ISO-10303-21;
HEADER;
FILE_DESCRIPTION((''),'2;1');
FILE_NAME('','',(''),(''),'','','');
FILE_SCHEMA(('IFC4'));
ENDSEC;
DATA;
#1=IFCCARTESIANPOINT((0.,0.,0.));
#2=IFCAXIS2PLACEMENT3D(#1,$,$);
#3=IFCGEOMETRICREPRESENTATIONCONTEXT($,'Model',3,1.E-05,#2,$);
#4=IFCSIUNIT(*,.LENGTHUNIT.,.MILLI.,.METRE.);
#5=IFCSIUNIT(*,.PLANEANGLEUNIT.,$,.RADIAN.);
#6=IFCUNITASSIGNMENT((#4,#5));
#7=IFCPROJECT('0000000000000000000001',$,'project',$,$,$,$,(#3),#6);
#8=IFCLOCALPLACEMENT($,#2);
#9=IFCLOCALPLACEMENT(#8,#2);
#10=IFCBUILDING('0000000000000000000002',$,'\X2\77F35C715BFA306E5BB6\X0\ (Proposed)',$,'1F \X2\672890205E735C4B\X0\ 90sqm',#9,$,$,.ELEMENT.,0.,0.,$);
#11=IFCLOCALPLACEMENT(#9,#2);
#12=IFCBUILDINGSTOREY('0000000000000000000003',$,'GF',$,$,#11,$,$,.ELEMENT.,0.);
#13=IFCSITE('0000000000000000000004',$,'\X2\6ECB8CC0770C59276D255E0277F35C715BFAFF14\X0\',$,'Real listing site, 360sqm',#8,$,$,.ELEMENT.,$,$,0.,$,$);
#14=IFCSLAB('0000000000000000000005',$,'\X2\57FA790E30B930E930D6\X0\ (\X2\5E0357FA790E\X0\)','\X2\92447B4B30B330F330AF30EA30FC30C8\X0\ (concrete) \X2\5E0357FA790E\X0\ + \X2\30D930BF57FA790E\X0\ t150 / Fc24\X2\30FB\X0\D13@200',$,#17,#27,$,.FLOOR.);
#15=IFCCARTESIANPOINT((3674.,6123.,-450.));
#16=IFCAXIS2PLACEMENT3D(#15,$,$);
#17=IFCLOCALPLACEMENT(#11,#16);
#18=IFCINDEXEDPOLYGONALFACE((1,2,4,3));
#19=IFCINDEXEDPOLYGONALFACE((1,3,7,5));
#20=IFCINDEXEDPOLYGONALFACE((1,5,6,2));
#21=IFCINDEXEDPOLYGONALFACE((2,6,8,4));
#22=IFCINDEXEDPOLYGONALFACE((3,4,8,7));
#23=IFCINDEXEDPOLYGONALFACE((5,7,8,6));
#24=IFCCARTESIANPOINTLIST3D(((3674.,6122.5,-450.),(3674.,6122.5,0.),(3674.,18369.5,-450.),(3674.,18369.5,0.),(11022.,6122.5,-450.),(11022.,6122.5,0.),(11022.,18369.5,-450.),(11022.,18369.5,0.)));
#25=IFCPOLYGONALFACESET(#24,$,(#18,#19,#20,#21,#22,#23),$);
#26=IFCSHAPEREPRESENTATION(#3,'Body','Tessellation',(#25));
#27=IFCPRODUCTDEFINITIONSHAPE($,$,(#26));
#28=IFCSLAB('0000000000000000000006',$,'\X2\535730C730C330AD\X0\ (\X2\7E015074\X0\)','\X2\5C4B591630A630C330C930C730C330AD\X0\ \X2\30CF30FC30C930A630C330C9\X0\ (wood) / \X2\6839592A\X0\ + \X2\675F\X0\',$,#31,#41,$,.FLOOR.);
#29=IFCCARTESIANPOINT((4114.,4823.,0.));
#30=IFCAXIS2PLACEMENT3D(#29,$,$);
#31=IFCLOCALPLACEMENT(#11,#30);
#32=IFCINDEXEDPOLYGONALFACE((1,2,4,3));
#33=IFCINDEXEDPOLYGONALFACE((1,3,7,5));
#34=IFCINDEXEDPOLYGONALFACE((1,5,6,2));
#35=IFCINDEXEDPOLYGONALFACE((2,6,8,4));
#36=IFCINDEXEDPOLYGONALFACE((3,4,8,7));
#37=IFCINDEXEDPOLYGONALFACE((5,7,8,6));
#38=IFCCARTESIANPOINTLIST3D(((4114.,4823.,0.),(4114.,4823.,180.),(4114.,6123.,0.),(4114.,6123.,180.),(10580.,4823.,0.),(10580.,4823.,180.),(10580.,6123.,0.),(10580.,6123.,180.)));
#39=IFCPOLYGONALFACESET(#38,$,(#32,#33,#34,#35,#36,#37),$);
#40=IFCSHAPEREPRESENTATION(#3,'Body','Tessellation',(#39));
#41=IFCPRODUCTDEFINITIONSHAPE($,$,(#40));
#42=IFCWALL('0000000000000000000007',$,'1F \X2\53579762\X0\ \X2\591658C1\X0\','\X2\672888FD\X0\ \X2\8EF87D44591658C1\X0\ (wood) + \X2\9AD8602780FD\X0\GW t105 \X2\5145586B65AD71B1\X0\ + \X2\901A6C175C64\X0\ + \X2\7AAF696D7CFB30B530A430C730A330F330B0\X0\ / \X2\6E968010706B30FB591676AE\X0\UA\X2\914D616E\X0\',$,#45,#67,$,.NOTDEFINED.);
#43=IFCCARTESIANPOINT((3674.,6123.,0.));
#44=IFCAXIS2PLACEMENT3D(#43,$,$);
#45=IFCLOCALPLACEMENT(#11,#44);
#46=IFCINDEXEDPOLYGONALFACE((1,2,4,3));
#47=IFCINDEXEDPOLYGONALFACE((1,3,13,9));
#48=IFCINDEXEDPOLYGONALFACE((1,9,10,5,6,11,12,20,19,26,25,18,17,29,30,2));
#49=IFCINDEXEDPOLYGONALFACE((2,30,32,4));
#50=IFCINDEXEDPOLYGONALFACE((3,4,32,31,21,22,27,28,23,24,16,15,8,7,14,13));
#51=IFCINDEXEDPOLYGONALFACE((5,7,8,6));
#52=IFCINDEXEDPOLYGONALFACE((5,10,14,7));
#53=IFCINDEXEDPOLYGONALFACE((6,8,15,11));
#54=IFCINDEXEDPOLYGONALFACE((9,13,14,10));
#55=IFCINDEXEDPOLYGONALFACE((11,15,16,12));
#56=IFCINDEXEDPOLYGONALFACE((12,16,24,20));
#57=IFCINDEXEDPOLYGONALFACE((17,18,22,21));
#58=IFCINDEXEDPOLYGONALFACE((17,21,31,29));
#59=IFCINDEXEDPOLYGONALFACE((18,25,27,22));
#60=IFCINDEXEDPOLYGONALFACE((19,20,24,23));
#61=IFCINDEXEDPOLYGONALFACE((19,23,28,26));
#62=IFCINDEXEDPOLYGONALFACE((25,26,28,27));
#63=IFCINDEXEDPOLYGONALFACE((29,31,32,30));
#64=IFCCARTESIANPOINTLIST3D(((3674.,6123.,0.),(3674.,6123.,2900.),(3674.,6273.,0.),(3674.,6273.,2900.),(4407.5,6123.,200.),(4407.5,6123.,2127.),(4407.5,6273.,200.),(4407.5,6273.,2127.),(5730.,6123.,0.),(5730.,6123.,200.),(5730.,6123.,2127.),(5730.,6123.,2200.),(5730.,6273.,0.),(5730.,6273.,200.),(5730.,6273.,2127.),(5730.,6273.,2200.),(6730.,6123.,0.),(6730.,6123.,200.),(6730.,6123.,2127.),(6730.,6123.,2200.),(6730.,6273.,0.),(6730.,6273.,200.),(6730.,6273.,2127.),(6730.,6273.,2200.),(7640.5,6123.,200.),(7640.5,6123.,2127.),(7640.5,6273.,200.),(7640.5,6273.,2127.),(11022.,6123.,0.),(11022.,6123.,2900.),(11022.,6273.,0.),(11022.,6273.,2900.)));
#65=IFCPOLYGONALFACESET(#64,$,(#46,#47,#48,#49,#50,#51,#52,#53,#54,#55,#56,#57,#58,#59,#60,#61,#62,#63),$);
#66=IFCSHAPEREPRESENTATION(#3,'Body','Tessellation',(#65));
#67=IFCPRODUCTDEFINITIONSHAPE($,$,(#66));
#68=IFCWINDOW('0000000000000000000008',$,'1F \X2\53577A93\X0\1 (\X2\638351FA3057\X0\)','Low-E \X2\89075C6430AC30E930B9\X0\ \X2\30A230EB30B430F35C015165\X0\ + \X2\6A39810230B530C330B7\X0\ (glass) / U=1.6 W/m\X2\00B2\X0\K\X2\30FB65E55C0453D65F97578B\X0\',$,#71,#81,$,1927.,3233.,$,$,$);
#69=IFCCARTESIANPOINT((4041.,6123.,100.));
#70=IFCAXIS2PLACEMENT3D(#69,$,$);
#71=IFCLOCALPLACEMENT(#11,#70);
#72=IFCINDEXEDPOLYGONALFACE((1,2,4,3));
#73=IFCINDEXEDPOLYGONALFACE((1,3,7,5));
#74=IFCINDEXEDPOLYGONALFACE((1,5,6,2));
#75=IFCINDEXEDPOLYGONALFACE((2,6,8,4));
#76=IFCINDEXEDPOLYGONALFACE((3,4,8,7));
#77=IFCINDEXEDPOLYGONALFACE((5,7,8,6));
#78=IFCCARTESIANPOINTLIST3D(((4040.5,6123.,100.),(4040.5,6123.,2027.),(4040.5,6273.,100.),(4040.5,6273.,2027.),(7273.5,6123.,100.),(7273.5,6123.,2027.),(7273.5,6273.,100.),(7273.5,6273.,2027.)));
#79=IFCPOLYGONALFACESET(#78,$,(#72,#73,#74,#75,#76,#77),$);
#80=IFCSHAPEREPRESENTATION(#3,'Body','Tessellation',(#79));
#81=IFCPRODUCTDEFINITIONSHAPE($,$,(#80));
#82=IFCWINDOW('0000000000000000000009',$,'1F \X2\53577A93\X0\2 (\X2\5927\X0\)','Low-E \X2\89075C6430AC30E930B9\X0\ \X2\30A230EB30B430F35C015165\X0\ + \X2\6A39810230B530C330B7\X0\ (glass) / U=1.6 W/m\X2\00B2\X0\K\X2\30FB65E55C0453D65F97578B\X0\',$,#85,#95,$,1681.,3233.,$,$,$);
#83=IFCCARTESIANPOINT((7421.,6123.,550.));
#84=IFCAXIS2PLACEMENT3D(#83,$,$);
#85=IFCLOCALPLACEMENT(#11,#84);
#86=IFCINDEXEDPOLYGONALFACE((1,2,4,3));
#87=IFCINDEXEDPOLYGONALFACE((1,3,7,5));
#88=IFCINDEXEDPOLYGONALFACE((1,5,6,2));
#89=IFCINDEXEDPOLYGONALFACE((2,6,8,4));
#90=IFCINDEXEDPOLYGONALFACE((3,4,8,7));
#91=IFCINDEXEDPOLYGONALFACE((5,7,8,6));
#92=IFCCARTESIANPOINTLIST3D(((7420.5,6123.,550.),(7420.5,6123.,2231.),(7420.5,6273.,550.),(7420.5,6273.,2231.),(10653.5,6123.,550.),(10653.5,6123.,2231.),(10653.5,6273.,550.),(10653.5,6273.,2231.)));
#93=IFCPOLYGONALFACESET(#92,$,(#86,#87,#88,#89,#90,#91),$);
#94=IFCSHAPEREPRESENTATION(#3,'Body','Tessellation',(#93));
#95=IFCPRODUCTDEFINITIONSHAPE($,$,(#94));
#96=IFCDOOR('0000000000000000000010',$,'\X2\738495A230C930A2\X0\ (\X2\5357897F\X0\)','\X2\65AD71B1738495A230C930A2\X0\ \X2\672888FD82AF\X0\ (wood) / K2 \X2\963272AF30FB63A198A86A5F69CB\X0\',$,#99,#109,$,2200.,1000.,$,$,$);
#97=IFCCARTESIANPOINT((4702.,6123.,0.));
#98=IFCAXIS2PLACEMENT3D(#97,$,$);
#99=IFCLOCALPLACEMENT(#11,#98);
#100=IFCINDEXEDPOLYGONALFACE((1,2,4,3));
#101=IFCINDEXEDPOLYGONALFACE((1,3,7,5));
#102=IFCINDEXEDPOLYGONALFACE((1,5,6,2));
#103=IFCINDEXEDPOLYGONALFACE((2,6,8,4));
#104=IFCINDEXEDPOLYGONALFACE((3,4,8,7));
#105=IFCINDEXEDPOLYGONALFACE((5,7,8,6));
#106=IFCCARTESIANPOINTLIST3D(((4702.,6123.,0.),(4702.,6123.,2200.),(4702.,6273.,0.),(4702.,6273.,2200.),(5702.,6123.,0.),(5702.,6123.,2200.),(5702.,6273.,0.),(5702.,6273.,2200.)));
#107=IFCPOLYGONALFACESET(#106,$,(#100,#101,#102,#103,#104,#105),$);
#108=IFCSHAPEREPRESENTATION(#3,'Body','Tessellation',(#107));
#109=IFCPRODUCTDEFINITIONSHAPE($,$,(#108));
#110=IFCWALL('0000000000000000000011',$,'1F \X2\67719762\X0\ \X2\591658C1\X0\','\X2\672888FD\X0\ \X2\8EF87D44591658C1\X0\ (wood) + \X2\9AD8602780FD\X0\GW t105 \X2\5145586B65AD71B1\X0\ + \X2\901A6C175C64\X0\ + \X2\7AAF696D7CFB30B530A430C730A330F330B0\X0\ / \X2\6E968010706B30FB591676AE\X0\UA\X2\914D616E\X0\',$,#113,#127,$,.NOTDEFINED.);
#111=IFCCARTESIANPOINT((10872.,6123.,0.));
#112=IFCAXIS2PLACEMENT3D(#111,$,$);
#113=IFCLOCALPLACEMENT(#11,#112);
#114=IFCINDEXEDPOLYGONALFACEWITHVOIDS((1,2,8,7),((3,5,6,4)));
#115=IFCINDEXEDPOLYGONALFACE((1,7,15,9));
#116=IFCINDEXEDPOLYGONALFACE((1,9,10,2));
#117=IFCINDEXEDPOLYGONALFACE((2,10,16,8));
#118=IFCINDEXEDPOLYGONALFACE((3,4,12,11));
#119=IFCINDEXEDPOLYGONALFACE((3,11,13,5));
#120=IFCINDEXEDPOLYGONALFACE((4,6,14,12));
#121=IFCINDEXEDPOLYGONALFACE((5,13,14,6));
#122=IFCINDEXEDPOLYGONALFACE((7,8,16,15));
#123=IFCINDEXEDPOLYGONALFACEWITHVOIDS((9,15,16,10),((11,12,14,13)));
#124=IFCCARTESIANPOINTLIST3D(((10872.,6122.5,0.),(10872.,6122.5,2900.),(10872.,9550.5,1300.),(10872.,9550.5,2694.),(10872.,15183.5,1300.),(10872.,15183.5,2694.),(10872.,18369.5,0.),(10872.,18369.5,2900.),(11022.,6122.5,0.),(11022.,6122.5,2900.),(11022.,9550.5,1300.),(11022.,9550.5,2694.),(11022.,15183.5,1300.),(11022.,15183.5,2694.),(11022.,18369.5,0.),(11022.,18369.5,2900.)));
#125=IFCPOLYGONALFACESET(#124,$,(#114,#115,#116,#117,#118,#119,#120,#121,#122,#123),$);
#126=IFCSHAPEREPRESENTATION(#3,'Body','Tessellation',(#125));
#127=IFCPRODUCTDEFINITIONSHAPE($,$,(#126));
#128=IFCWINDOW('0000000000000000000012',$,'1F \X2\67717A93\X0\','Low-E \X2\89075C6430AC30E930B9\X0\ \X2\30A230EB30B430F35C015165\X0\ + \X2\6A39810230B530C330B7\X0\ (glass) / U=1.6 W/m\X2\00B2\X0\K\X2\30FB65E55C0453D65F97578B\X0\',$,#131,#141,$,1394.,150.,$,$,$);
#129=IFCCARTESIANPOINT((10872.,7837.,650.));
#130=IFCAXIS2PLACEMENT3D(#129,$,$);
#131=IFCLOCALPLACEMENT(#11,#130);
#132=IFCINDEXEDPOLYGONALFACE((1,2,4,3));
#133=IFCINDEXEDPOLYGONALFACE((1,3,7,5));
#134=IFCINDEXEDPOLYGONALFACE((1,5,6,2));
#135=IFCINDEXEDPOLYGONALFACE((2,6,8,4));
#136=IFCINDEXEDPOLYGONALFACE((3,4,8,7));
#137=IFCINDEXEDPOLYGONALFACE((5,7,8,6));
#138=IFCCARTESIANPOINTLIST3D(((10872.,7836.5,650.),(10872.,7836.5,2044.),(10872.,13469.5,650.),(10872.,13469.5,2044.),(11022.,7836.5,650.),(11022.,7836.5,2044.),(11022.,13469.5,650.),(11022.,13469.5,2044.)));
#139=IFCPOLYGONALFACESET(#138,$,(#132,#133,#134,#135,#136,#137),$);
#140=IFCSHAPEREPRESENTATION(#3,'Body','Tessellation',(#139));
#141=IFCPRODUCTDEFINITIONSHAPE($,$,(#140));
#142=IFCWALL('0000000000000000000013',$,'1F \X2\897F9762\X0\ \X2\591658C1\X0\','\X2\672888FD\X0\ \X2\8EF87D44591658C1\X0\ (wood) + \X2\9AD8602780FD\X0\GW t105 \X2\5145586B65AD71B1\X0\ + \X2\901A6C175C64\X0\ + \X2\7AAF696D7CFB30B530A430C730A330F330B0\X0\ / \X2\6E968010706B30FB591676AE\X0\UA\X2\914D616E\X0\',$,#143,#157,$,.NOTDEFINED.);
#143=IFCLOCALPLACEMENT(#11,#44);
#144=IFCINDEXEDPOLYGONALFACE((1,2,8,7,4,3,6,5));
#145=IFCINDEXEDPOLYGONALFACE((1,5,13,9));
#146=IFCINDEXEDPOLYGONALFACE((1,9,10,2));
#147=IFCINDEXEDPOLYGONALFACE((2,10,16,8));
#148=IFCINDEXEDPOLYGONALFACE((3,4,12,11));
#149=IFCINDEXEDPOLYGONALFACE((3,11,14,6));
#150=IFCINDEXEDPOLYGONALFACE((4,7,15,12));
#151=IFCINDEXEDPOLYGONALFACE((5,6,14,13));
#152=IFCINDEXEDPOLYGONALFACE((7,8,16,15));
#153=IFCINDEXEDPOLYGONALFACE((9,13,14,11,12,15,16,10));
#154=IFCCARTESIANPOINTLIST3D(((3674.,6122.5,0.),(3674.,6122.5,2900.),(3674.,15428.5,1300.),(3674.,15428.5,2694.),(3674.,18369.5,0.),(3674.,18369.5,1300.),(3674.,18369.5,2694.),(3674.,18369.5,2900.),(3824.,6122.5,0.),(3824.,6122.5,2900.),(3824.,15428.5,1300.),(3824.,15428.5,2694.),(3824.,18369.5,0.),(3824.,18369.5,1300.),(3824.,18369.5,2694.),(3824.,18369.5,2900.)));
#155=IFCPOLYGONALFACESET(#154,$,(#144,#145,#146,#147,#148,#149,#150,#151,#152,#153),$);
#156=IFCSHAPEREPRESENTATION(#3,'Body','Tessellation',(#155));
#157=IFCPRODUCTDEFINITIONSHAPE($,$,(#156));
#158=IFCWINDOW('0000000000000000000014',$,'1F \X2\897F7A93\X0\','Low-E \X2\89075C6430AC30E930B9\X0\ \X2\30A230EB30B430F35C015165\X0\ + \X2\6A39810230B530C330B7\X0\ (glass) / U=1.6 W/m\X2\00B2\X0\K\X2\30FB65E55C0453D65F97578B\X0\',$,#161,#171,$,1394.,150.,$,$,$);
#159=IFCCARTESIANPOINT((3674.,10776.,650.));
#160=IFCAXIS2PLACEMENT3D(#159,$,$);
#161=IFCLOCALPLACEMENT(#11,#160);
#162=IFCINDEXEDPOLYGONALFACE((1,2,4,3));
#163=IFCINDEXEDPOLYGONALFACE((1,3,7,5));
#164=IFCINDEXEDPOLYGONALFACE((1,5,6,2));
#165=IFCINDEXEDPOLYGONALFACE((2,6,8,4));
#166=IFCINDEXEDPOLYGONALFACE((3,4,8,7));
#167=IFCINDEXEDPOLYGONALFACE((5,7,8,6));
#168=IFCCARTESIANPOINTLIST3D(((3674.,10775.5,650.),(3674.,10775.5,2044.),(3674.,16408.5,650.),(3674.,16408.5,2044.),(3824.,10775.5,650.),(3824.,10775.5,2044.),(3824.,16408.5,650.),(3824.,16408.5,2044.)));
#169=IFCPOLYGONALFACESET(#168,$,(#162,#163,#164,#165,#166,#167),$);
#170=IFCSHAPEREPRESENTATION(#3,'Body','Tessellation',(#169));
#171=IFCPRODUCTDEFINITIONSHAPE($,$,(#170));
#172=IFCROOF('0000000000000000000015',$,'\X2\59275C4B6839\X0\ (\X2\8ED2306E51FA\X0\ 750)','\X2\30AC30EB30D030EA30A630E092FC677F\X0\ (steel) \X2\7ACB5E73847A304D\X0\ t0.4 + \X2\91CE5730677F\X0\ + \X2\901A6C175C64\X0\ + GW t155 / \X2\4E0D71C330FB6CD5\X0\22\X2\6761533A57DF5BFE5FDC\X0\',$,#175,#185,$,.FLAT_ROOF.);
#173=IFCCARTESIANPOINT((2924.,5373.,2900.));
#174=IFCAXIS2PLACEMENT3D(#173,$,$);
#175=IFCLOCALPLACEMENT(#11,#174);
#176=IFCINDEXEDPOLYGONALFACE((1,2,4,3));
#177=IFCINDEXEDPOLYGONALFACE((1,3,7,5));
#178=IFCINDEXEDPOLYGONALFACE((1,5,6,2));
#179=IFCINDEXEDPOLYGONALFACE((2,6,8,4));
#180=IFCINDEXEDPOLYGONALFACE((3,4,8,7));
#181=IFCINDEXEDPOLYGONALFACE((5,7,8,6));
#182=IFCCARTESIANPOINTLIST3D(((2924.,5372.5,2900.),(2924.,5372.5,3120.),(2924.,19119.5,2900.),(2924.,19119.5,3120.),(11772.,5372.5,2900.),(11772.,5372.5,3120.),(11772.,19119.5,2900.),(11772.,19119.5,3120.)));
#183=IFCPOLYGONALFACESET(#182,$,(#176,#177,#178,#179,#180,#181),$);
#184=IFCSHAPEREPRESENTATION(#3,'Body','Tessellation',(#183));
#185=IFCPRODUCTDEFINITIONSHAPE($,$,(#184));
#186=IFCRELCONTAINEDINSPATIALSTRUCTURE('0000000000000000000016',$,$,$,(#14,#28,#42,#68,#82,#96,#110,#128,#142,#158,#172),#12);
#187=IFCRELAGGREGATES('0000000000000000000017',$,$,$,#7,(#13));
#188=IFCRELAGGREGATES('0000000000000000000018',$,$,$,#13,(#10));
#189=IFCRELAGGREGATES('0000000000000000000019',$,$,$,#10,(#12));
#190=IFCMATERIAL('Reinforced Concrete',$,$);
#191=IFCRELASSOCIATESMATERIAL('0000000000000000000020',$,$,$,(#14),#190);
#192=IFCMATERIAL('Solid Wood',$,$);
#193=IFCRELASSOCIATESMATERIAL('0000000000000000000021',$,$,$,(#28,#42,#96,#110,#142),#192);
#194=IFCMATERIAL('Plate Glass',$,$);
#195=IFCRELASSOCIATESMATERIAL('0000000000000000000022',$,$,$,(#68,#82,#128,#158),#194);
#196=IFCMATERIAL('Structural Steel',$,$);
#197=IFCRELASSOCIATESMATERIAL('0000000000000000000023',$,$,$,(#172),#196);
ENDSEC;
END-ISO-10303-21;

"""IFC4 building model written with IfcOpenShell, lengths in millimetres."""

from ifc_helpers import new_model, si_unit, frame, frame_2d, origin, place, context, project, spatial, rectangle, extrude, material, element, fill, save


model = new_model("IFC4")

# Units and contexts
model_context = context("Model", 3, precision=1e-05, world=origin())
ifc_project = project(units=[si_unit("LENGTHUNIT", "METRE", prefix="MILLI"), si_unit("PLANEANGLEUNIT", "RADIAN")], contexts=[model_context])

# Site, building, storey
site_placement = place(None, origin())
site = spatial("IfcSite", under=ifc_project, at=site_placement, Name="滋賀県大津市石山寺４", ObjectType="Real listing site, 360sqm", CompositionType="ELEMENT", RefElevation=0.0)
building_placement = place(site_placement, origin())
building = spatial("IfcBuilding", under=site, at=building_placement, Name="石山寺の家 (Proposed)", ObjectType="1F 木造平屋 90sqm", CompositionType="ELEMENT", ElevationOfRefHeight=0.0, ElevationOfTerrain=0.0)
storey_placement = place(building_placement, origin())
storey = spatial("IfcBuildingStorey", under=building, at=storey_placement, Name="GF", CompositionType="ELEMENT", Elevation=0.0)

# Slabs
ifc_material_1 = material(Name="Reinforced Concrete")
slab_1_placement = place(storey_placement, frame((3674.0, 6123.0, -450.0)))
element("IfcSlab", 1, at=slab_1_placement, inside=storey, material=ifc_material_1, Name="基礎スラブ (布基礎)", Description="鉄筋コンクリート (concrete) 布基礎 + ベタ基礎 t150 / Fc24・D13@200", PredefinedType="FLOOR", context=model_context, shape_type="SweptSolid", body=[
    extrude(rectangle(XDim=7348.0, YDim=12247.0, at=frame_2d((3674.0, 6123.0))), frame((3674.0, 6123.0, -450.0)), (0.0, 0.0, 1.0), 450.0),
])
ifc_material_2 = material(Name="Solid Wood")
slab_2_placement = place(storey_placement, frame((4114.0, 4823.0, 0.0)))
element("IfcSlab", 2, at=slab_2_placement, inside=storey, material=ifc_material_2, Name="南デッキ (縁側)", Description="屋外ウッドデッキ ハードウッド (wood) / 根太 + 束", PredefinedType="FLOOR", context=model_context, shape_type="SweptSolid", body=[
    extrude(rectangle(XDim=6466.0, YDim=1300.0, at=frame_2d((3233.0, 650.0))), frame((4114.0, 4823.0, 0.0)), (0.0, 0.0, 1.0), 180.0),
])

# Wall, openings, windows, door
wall_1_placement = place(storey_placement, frame((3674.0, 6123.0, 0.0)))
wall_1 = element("IfcWall", 3, at=wall_1_placement, inside=storey, material=ifc_material_2, Name="1F 南面 外壁", Description="木製 軸組外壁 (wood) + 高性能GW t105 充填断熱 + 通気層 + 窯業系サイディング / 準耐火・外皮UA配慮", PredefinedType="NOTDEFINED", context=model_context, shape_type="SweptSolid", body=[
    extrude(rectangle(XDim=7348.0, YDim=150.0, at=frame_2d((3674.0, 75.0))), frame((3674.0, 6123.0, 0.0)), (0.0, 0.0, 1.0), 2900.0),
])
opening_1_placement = place(storey_placement, frame((4041.0, 6123.0, 100.0)))
opening_1 = element("IfcOpeningElement", 4, at=opening_1_placement, cuts=wall_1, PredefinedType="NOTDEFINED", context=model_context, shape_type="SweptSolid", body=[
    extrude(rectangle(XDim=3233.0, YDim=150.0, at=frame_2d((1616.0, 75.0))), frame((4041.0, 6123.0, 100.0)), (0.0, 0.0, 1.0), 1927.0),
])
opening_2_placement = place(storey_placement, frame((7421.0, 6123.0, 550.0)))
opening_2 = element("IfcOpeningElement", 5, at=opening_2_placement, cuts=wall_1, PredefinedType="NOTDEFINED", context=model_context, shape_type="SweptSolid", body=[
    extrude(rectangle(XDim=3233.0, YDim=150.0, at=frame_2d((1616.0, 75.0))), frame((7421.0, 6123.0, 550.0)), (0.0, 0.0, 1.0), 1681.0),
])
opening_3_placement = place(storey_placement, frame((4702.0, 6123.0, 0.0)))
opening_3 = element("IfcOpeningElement", 6, at=opening_3_placement, cuts=wall_1, PredefinedType="NOTDEFINED", context=model_context, shape_type="SweptSolid", body=[
    extrude(rectangle(XDim=1000.0, YDim=150.0, at=frame_2d((500.0, 75.0))), frame((4702.0, 6123.0, 0.0)), (0.0, 0.0, 1.0), 2200.0),
])
ifc_material_3 = material(Name="Plate Glass")
window_1_placement = place(storey_placement, frame((4041.0, 6123.0, 100.0)))
window_1 = element("IfcWindow", 7, at=window_1_placement, inside=storey, material=ifc_material_3, Name="1F 南窓1 (掃出し)", Description="Low-E 複層ガラス アルゴン封入 + 樹脂サッシ (glass) / U=1.6 W/m²K・日射取得型", OverallHeight=1927.0, OverallWidth=3233.0, context=model_context, shape_type="SweptSolid", body=[
    extrude(rectangle(XDim=3233.0, YDim=150.0, at=frame_2d((1616.0, 75.0))), frame((4041.0, 6123.0, 100.0)), (0.0, 0.0, 1.0), 1927.0),
])
fill(opening_1, window_1)
window_2_placement = place(storey_placement, frame((7421.0, 6123.0, 550.0)))
window_2 = element("IfcWindow", 8, at=window_2_placement, inside=storey, material=ifc_material_3, Name="1F 南窓2 (大)", Description="Low-E 複層ガラス アルゴン封入 + 樹脂サッシ (glass) / U=1.6 W/m²K・日射取得型", OverallHeight=1681.0, OverallWidth=3233.0, context=model_context, shape_type="SweptSolid", body=[
    extrude(rectangle(XDim=3233.0, YDim=150.0, at=frame_2d((1616.0, 75.0))), frame((7421.0, 6123.0, 550.0)), (0.0, 0.0, 1.0), 1681.0),
])
fill(opening_2, window_2)
door_placement = place(storey_placement, frame((4702.0, 6123.0, 0.0)))
door = element("IfcDoor", 9, at=door_placement, inside=storey, material=ifc_material_2, Name="玄関ドア (南西)", Description="断熱玄関ドア 木製芯 (wood) / K2 防犯・採風機構", OverallHeight=2200.0, OverallWidth=1000.0, context=model_context, shape_type="SweptSolid", body=[
    extrude(rectangle(XDim=1000.0, YDim=150.0, at=frame_2d((500.0, 75.0))), frame((4702.0, 6123.0, 0.0)), (0.0, 0.0, 1.0), 2200.0),
])
fill(opening_3, door)

# Walls, openings, windows
wall_2_placement = place(storey_placement, frame((10872.0, 6123.0, 0.0)))
wall_2 = element("IfcWall", 10, at=wall_2_placement, inside=storey, material=ifc_material_2, Name="1F 東面 外壁", Description="木製 軸組外壁 (wood) + 高性能GW t105 充填断熱 + 通気層 + 窯業系サイディング / 準耐火・外皮UA配慮", PredefinedType="NOTDEFINED", context=model_context, shape_type="SweptSolid", body=[
    extrude(rectangle(XDim=150.0, YDim=12247.0, at=frame_2d((75.0, 6123.0))), frame((10872.0, 6123.0, 0.0)), (0.0, 0.0, 1.0), 2900.0),
])
opening_4_placement = place(storey_placement, frame((10872.0, 7837.0, 650.0)))
opening_4 = element("IfcOpeningElement", 11, at=opening_4_placement, cuts=wall_2, PredefinedType="NOTDEFINED", context=model_context, shape_type="SweptSolid", body=[
    extrude(rectangle(XDim=150.0, YDim=5633.0, at=frame_2d((75.0, 2816.0))), frame((10872.0, 7837.0, 650.0)), (0.0, 0.0, 1.0), 1394.0),
])
window_3_placement = place(storey_placement, frame((10872.0, 7837.0, 650.0)))
window_3 = element("IfcWindow", 12, at=window_3_placement, inside=storey, material=ifc_material_3, Name="1F 東窓", Description="Low-E 複層ガラス アルゴン封入 + 樹脂サッシ (glass) / U=1.6 W/m²K・日射取得型", OverallHeight=1394.0, OverallWidth=150.0, context=model_context, shape_type="SweptSolid", body=[
    extrude(rectangle(XDim=150.0, YDim=5633.0, at=frame_2d((75.0, 2816.0))), frame((10872.0, 7837.0, 650.0)), (0.0, 0.0, 1.0), 1394.0),
])
fill(opening_4, window_3)
wall_3_placement = place(storey_placement, frame((3674.0, 6123.0, 0.0)))
wall_3 = element("IfcWall", 13, at=wall_3_placement, inside=storey, material=ifc_material_2, Name="1F 西面 外壁", Description="木製 軸組外壁 (wood) + 高性能GW t105 充填断熱 + 通気層 + 窯業系サイディング / 準耐火・外皮UA配慮", PredefinedType="NOTDEFINED", context=model_context, shape_type="SweptSolid", body=[
    extrude(rectangle(XDim=150.0, YDim=12247.0, at=frame_2d((75.0, 6123.0))), frame((3674.0, 6123.0, 0.0)), (0.0, 0.0, 1.0), 2900.0),
])
opening_5_placement = place(storey_placement, frame((3674.0, 10776.0, 650.0)))
opening_5 = element("IfcOpeningElement", 14, at=opening_5_placement, cuts=wall_3, PredefinedType="NOTDEFINED", context=model_context, shape_type="SweptSolid", body=[
    extrude(rectangle(XDim=150.0, YDim=5633.0, at=frame_2d((75.0, 2816.0))), frame((3674.0, 10776.0, 650.0)), (0.0, 0.0, 1.0), 1394.0),
])
window_4_placement = place(storey_placement, frame((3674.0, 10776.0, 650.0)))
window_4 = element("IfcWindow", 15, at=window_4_placement, inside=storey, material=ifc_material_3, Name="1F 西窓", Description="Low-E 複層ガラス アルゴン封入 + 樹脂サッシ (glass) / U=1.6 W/m²K・日射取得型", OverallHeight=1394.0, OverallWidth=150.0, context=model_context, shape_type="SweptSolid", body=[
    extrude(rectangle(XDim=150.0, YDim=5633.0, at=frame_2d((75.0, 2816.0))), frame((3674.0, 10776.0, 650.0)), (0.0, 0.0, 1.0), 1394.0),
])
fill(opening_5, window_4)

# Roof
ifc_material_4 = material(Name="Structural Steel")
roof_placement = place(storey_placement, frame((2924.0, 5373.0, 2900.0)))
element("IfcRoof", 16, at=roof_placement, inside=storey, material=ifc_material_4, Name="大屋根 (軒の出 750)", Description="ガルバリウム鋼板 (steel) 立平葺き t0.4 + 野地板 + 通気層 + GW t155 / 不燃・法22条区域対応", PredefinedType="FLAT_ROOF", context=model_context, shape_type="SweptSolid", body=[
    extrude(rectangle(XDim=8848.0, YDim=13747.0, at=frame_2d((4424.0, 6873.0))), frame((2924.0, 5373.0, 2900.0)), (0.0, 0.0, 1.0), 220.0),
])

save(model, "model.ifc")
